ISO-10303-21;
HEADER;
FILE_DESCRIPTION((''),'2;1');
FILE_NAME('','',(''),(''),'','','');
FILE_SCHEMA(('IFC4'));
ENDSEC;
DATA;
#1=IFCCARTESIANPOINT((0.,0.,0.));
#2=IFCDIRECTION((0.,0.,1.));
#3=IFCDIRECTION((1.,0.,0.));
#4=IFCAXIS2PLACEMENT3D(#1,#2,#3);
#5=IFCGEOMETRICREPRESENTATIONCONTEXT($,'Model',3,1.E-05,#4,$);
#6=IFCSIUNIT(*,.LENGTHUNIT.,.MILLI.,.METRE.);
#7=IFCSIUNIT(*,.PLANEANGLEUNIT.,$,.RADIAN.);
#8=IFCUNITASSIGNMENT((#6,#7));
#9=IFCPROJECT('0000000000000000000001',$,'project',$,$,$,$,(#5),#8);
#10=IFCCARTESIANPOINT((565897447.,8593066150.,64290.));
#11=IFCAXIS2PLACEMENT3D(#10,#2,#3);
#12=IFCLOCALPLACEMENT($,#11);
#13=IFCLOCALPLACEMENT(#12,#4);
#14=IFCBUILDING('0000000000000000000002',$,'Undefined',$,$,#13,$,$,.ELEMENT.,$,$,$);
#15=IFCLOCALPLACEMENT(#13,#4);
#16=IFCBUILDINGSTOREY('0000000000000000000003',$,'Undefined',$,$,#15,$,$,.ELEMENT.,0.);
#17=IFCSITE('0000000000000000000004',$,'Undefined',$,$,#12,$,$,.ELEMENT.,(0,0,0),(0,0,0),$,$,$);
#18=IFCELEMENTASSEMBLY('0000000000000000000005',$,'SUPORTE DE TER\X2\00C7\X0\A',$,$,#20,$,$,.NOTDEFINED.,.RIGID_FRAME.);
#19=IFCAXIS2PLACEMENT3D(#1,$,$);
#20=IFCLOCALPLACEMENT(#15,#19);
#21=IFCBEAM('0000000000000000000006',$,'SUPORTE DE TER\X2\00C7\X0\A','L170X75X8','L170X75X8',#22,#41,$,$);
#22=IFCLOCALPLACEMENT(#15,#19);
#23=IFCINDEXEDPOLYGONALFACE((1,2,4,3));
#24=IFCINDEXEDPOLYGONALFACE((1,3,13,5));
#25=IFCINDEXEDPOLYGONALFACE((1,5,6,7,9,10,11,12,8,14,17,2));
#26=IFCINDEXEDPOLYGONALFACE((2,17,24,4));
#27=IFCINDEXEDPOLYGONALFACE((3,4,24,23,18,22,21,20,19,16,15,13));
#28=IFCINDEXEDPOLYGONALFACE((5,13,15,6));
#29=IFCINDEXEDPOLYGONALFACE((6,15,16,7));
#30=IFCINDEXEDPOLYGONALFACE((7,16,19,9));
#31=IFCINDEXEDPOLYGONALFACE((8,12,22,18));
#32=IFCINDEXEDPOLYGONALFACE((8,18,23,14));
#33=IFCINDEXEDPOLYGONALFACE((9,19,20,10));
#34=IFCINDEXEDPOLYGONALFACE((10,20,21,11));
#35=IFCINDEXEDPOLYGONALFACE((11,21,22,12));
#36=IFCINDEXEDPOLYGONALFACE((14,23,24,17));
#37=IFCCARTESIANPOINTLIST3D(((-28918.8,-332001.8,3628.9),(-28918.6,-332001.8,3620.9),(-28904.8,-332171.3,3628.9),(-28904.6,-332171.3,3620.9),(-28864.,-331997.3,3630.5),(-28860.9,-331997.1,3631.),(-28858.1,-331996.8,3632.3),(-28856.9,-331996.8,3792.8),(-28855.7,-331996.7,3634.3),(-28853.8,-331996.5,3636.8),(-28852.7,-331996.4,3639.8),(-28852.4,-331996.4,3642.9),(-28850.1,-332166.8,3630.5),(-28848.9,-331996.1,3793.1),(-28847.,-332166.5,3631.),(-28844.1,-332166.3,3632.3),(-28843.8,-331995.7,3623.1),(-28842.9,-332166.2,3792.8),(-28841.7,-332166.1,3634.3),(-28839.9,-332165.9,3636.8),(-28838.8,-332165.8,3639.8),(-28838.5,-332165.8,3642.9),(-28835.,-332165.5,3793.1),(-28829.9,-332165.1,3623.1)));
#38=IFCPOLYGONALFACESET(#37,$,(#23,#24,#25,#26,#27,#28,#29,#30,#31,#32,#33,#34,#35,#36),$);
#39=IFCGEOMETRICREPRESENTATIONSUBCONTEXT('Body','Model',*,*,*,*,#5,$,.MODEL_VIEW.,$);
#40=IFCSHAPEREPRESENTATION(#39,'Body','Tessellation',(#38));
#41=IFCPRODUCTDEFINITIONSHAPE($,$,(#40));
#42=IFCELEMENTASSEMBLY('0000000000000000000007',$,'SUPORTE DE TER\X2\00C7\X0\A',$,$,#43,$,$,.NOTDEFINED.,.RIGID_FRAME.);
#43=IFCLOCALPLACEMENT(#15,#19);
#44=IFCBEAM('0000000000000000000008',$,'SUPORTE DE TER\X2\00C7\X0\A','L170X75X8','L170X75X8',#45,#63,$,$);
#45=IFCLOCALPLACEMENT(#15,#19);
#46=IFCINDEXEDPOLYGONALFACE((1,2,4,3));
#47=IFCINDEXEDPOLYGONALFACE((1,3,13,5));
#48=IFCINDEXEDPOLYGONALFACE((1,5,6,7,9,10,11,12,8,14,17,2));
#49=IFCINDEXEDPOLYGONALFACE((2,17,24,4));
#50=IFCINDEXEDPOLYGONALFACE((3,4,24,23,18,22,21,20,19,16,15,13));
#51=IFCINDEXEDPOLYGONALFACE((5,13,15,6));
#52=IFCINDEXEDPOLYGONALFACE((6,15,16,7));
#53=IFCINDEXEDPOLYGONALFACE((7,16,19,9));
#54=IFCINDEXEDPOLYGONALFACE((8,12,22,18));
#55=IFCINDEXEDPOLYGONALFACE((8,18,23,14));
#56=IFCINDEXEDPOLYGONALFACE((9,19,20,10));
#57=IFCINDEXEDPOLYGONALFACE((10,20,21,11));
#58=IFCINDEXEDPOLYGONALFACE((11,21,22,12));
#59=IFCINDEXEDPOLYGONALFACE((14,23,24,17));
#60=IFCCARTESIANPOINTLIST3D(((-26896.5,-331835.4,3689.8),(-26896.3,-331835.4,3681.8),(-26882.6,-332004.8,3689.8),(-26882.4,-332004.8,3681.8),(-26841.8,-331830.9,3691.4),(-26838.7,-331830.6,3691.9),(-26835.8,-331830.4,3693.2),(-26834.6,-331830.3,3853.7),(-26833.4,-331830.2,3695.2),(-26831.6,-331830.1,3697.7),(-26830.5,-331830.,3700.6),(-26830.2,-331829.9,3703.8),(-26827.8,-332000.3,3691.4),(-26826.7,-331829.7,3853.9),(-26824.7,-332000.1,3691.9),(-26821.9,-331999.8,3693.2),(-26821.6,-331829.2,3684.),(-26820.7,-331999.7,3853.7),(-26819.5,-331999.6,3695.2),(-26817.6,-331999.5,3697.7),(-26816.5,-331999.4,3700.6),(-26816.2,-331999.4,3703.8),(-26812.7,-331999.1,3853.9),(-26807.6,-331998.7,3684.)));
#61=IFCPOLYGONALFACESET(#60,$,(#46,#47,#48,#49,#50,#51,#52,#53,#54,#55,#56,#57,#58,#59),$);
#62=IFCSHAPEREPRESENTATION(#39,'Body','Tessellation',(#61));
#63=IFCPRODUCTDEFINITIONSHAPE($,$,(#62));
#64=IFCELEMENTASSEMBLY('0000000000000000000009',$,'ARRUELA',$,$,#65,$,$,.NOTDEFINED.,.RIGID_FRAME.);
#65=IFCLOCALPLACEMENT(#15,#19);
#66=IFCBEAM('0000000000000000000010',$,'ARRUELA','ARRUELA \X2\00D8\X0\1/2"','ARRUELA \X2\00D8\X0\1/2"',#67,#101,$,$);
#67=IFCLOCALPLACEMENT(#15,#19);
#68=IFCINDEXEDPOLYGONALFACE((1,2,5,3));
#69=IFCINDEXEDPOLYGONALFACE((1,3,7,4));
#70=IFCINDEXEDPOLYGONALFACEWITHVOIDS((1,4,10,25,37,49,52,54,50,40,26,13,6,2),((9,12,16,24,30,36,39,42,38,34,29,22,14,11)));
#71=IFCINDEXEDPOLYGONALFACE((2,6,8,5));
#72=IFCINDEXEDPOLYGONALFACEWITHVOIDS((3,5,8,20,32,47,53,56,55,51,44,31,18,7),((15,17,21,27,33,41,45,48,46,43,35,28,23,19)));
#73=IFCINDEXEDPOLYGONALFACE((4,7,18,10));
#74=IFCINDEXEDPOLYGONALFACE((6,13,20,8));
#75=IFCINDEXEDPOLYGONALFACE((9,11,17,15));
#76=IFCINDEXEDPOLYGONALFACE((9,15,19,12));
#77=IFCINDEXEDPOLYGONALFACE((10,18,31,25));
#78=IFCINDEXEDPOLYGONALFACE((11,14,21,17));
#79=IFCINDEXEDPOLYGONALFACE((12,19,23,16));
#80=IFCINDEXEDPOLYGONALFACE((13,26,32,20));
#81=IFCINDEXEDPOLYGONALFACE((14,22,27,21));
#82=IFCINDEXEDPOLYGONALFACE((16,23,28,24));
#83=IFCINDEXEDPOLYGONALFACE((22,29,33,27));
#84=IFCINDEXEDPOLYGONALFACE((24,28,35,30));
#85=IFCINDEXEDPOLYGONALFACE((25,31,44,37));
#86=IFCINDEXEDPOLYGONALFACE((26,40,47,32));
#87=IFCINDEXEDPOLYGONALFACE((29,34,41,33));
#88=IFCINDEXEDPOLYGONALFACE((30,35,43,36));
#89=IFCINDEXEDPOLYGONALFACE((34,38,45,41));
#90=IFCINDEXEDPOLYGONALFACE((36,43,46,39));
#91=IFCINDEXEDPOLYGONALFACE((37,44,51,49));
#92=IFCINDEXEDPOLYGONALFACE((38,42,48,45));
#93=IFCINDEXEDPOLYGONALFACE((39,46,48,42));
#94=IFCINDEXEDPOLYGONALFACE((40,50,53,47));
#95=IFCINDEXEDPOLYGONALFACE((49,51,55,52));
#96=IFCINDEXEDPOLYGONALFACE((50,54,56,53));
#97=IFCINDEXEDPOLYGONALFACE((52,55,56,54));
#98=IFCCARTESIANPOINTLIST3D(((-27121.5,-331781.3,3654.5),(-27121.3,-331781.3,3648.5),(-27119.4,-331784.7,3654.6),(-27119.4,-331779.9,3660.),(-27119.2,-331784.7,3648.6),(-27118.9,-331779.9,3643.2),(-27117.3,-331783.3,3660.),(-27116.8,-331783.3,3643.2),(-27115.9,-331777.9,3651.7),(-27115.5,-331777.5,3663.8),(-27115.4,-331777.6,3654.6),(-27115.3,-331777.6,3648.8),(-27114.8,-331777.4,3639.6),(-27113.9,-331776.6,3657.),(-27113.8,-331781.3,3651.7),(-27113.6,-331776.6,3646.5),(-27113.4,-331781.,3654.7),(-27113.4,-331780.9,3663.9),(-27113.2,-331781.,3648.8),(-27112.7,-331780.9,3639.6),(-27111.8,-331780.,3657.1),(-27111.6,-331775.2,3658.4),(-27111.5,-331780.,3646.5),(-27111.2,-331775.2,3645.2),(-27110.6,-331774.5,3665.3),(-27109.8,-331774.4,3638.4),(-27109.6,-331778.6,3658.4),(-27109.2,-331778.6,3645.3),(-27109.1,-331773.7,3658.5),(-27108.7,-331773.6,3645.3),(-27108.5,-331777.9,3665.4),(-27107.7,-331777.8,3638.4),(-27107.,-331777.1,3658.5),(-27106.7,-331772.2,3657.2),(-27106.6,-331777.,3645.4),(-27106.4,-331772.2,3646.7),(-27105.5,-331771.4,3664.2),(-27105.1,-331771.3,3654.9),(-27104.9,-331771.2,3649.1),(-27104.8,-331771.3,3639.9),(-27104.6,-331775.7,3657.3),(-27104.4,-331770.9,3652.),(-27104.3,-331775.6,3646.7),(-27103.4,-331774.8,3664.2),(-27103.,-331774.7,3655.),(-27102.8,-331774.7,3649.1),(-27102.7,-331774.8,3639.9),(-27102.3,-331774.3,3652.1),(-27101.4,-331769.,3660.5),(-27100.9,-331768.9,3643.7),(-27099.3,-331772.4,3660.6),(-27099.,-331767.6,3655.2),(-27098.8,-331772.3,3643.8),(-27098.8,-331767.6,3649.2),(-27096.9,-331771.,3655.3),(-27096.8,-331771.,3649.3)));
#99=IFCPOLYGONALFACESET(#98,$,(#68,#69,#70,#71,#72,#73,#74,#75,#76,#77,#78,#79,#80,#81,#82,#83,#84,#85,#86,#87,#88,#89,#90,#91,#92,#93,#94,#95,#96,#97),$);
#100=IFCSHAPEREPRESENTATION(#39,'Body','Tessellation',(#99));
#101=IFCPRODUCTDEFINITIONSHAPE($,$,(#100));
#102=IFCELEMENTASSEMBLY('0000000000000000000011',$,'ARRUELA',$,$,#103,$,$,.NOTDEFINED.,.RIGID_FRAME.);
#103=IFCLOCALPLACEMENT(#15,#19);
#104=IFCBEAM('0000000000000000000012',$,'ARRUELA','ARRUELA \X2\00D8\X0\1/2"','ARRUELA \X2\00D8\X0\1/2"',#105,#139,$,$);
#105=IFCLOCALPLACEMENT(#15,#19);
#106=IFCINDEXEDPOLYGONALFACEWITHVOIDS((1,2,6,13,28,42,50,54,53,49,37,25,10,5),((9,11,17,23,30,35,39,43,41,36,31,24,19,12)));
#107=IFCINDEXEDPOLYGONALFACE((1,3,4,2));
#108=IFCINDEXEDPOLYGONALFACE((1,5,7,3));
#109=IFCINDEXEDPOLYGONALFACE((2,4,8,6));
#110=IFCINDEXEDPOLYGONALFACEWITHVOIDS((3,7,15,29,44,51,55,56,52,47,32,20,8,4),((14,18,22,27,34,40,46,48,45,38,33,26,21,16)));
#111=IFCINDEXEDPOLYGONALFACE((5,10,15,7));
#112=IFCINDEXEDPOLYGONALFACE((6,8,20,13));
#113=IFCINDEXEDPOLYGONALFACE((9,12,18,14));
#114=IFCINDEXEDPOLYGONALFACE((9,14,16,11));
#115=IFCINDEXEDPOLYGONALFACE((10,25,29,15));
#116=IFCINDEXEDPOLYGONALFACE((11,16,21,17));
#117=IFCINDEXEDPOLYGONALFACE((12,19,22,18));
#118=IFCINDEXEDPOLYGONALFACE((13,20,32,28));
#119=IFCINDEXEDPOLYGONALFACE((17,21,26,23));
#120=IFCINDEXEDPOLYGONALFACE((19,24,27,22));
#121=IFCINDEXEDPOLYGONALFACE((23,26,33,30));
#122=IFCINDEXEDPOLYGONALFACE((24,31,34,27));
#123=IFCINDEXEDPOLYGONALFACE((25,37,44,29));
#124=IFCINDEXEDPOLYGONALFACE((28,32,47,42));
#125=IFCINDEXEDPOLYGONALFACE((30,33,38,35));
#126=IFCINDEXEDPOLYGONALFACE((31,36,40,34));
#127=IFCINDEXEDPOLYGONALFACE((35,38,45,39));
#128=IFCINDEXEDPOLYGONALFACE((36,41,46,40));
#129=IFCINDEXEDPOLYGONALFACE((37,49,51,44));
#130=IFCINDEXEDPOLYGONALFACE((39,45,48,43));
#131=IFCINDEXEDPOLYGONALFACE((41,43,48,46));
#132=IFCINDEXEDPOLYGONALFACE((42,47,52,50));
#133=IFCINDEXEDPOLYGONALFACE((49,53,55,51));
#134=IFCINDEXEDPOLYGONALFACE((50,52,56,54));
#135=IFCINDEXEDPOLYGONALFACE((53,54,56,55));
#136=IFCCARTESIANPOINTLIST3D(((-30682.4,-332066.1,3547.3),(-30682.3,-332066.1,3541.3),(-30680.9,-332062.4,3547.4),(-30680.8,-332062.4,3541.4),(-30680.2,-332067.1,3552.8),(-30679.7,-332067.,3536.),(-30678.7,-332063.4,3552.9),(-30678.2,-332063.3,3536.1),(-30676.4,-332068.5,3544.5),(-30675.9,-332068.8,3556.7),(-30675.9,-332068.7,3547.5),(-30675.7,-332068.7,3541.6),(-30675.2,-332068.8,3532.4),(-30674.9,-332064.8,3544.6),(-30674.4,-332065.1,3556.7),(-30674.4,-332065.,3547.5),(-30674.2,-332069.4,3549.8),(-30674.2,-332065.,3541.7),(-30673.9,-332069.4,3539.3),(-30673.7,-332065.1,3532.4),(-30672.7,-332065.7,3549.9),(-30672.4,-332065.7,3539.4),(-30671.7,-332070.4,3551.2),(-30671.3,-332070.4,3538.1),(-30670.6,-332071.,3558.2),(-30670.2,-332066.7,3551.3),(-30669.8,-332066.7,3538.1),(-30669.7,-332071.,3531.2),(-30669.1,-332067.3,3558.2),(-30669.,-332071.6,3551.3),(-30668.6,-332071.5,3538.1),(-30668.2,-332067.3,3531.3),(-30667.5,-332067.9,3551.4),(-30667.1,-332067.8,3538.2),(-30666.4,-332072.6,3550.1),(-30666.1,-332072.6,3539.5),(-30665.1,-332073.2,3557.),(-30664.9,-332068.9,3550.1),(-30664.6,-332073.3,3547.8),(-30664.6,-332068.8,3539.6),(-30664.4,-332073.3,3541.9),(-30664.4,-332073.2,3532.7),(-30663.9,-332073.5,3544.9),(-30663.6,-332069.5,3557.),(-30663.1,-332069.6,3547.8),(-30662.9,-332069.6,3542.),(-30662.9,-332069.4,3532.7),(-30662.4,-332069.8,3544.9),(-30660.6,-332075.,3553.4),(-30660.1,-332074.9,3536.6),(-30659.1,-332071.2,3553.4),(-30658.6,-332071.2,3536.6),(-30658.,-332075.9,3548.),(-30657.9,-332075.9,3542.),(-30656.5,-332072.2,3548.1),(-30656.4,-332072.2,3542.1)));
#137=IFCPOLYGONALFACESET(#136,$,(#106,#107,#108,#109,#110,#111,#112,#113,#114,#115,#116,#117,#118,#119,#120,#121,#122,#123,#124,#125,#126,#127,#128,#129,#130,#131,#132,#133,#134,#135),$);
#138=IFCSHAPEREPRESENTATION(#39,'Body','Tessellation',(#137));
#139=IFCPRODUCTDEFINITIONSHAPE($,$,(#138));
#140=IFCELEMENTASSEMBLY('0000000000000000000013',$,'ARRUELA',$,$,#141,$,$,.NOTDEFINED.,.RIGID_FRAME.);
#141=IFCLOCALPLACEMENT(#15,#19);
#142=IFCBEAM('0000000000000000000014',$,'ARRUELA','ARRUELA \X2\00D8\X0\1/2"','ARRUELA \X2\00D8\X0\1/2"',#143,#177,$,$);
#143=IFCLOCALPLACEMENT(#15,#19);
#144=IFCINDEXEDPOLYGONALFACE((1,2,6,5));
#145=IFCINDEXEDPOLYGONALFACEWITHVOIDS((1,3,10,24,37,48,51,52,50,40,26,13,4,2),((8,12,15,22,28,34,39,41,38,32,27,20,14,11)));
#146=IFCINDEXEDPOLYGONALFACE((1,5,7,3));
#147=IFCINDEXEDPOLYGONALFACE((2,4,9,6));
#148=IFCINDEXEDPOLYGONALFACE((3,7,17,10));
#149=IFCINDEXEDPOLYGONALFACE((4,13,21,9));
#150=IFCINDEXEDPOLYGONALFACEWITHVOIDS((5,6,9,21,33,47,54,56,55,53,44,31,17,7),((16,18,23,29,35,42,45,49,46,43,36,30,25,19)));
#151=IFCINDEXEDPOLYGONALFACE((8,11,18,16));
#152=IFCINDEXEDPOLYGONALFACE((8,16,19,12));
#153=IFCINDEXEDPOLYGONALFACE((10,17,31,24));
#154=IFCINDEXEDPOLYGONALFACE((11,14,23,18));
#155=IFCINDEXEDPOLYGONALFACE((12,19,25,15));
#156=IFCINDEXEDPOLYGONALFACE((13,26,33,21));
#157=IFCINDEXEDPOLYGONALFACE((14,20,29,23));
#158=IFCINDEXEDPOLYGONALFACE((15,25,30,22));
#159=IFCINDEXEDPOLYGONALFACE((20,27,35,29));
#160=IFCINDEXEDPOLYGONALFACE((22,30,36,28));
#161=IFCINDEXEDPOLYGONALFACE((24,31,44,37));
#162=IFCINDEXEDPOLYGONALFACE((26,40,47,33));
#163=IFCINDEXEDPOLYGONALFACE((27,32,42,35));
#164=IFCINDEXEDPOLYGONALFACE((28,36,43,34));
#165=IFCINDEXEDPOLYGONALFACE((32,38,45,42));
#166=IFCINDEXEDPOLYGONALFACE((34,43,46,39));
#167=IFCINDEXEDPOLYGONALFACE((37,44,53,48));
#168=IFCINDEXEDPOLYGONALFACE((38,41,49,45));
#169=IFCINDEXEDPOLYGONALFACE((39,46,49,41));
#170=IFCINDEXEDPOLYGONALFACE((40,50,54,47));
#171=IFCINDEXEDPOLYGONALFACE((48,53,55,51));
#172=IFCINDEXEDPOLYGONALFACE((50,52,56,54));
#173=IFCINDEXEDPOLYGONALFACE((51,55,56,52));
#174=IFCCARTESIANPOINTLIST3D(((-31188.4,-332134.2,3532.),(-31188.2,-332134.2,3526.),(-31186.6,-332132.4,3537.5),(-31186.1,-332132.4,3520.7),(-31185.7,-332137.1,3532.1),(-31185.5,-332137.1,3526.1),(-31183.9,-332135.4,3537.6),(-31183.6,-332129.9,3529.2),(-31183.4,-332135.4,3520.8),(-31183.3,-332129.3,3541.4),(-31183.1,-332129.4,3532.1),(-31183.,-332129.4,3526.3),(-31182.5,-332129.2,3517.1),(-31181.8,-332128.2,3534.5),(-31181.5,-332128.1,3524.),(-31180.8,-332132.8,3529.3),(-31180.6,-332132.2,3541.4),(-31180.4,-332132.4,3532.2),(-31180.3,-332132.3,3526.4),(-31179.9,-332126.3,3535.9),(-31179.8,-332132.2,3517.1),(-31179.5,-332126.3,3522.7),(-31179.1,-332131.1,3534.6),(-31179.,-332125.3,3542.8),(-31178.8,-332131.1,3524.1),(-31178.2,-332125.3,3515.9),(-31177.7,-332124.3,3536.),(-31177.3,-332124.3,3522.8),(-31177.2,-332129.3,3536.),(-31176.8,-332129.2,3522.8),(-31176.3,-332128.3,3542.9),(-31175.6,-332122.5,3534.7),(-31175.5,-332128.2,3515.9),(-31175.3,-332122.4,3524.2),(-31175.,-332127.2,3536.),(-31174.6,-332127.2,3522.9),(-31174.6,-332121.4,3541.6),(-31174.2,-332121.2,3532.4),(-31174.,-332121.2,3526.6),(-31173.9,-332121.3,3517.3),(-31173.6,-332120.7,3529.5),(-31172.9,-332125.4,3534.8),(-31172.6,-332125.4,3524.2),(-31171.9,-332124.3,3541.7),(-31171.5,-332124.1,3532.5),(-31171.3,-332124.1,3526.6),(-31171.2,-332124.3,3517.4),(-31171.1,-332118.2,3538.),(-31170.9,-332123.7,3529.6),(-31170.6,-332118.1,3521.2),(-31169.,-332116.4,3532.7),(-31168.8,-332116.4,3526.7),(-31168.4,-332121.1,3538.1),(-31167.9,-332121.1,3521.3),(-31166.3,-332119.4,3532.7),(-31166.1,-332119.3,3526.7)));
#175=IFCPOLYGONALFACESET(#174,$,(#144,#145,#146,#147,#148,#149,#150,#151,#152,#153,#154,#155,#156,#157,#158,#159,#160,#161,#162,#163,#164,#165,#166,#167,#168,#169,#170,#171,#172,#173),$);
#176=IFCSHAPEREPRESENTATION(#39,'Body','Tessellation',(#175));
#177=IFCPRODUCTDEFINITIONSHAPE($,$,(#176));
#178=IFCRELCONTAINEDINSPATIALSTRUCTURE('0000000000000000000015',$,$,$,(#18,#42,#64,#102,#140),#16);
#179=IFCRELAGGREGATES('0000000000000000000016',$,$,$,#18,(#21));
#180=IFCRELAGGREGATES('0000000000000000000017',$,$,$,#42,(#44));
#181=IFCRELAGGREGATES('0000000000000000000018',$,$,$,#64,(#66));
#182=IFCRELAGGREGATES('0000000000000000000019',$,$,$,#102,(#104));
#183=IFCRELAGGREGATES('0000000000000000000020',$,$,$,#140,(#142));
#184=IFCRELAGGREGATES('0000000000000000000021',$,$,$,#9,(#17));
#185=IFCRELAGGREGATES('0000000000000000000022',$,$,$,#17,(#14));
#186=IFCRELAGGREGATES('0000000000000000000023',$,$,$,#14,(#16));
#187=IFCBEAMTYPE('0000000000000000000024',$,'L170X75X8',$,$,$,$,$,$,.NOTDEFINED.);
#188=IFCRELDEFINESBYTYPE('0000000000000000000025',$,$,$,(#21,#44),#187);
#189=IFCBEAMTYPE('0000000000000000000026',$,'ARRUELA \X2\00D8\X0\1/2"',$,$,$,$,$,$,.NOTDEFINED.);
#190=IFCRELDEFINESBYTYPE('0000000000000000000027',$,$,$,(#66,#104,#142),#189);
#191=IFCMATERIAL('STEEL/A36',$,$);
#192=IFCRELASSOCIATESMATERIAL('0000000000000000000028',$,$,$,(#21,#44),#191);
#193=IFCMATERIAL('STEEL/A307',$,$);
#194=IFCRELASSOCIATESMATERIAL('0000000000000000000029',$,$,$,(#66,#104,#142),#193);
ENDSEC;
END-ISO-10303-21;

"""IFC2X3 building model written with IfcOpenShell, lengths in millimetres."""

from ifc_helpers import new_model, si_unit, frame, origin_with_axes, origin_2d_with_axis, place, context, subcontext, project, spatial, polyline, l_section, outline, extrude, material, type_object, element, aggregate, save


model = new_model("IFC2X3")

# Units and contexts
model_context = context("Model", 3, precision=1e-05, world=origin_with_axes())
body_context = subcontext(model_context, "Body", "Model", "MODEL_VIEW")
ifc_project = project(units=[si_unit("LENGTHUNIT", "METRE", prefix="MILLI"), si_unit("PLANEANGLEUNIT", "RADIAN")], contexts=[model_context])

# Site, building, storey
site_placement = place(None, frame((565897447.0, 8593066150.0, 64290.0), z_axis=(0.0, 0.0, 1.0), x_axis=(1.0, 0.0, 0.0)))
site = spatial("IfcSite", under=ifc_project, at=site_placement, Name="Undefined", CompositionType="ELEMENT", RefLatitude=(0, 0, 0), RefLongitude=(0, 0, 0))
building_placement = place(site_placement, origin_with_axes())
building = spatial("IfcBuilding", under=site, at=building_placement, Name="Undefined", CompositionType="ELEMENT")
storey_placement = place(building_placement, origin_with_axes())
storey = spatial("IfcBuildingStorey", under=building, at=storey_placement, Name="Undefined", CompositionType="ELEMENT", Elevation=0.0)

# Element assemblies, beams
ifc_material_1 = material(Name="STEEL/A36")
beam_type_1 = type_object("IfcBeamType", Name="L170X75X8", PredefinedType="NOTDEFINED")
assembly_1_placement = place(storey_placement, origin_with_axes())
assembly_1 = element("IfcElementAssembly", 1, at=assembly_1_placement, inside=storey, Name="SUPORTE DE TERÇA", AssemblyPlace="NOTDEFINED", PredefinedType="RIGID_FRAME")
beam_1_placement = place(assembly_1_placement, frame((-28883.7, -331999.0, 3707.0), z_axis=(-0.029885, -0.00246, 0.99955), x_axis=(0.082025, -0.99663, 0.0)))
beam_1 = element("IfcBeam", 2, at=beam_1_placement, type_object=beam_type_1, material=ifc_material_1, Name="SUPORTE DE TERÇA", Description="L170X75X8", ObjectType="L170X75X8", context=body_context, shape_type="SweptSolid", body=[
    extrude(l_section(Depth=170.0, Width=75.0, Thickness=8.0, FilletRadius=12.0, at=origin_2d_with_axis()), frame((170.0, 0.0, 0.0), z_axis=(-1.0, 0.0, 0.0), x_axis=(0.0, -1.0, 0.0)), (0.0, 0.0, 1.0), 170.0),
])
aggregate(assembly_1, [beam_1])
assembly_2_placement = place(storey_placement, origin_with_axes())
assembly_2 = element("IfcElementAssembly", 3, at=assembly_2_placement, inside=storey, Name="SUPORTE DE TERÇA", AssemblyPlace="NOTDEFINED", PredefinedType="RIGID_FRAME")
beam_2_placement = place(assembly_2_placement, frame((-26861.5, -331832.5, 3767.8), z_axis=(-0.029885, -0.00246, 0.99955), x_axis=(0.082025, -0.99663, 0.0)))
beam_2 = element("IfcBeam", 4, at=beam_2_placement, type_object=beam_type_1, material=ifc_material_1, Name="SUPORTE DE TERÇA", Description="L170X75X8", ObjectType="L170X75X8", context=body_context, shape_type="SweptSolid", body=[
    extrude(l_section(Depth=170.0, Width=75.0, Thickness=8.0, FilletRadius=12.0, at=origin_2d_with_axis()), frame((170.0, 0.0, 0.0), z_axis=(-1.0, 0.0, 0.0), x_axis=(0.0, -1.0, 0.0)), (0.0, 0.0, 1.0), 170.0),
])
aggregate(assembly_2, [beam_2])
assembly_3_placement = place(storey_placement, origin_with_axes())
assembly_3 = element("IfcElementAssembly", 5, at=assembly_3_placement, inside=storey, Name="ARRUELA", AssemblyPlace="NOTDEFINED", PredefinedType="RIGID_FRAME")
ifc_material_2 = material(Name="STEEL/A307")
beam_type_2 = type_object("IfcBeamType", Name="ARRUELA Ø1/2\"", PredefinedType="NOTDEFINED")
beam_3_placement = place(assembly_3_placement, frame((-27108.1, -331777.8, 3651.9), z_axis=(-0.853486, -0.520426, -0.026799), x_axis=(-0.520257, 0.853904, -0.013454)))
beam_3 = element("IfcBeam", 6, at=beam_3_placement, type_object=beam_type_2, material=ifc_material_2, Name="ARRUELA", Description="ARRUELA Ø1/2\"", ObjectType="ARRUELA Ø1/2\"", context=body_context, shape_type="SweptSolid", body=[
    extrude(outline(polyline([(-8.4, 10.5), (-3.0, 13.2), (3.0, 13.2), (8.4, 10.5), (12.2, 5.9), (13.5, 0.0), (12.2, -5.9), (8.4, -10.5), (3.0, -13.2), (-3.0, -13.2), (-8.4, -10.5), (-12.2, -5.9), (-13.5, 0.0), (-12.2, 5.9), (-8.4, 10.5)]), holes=[polyline([(5.3, 4.2), (2.9, 6.1), (0.0, 6.7), (-2.9, 6.1), (-5.3, 4.2), (-6.6, 1.5), (-6.6, -1.5), (-5.3, -4.2), (-2.9, -6.1), (0.0, -6.8), (2.9, -6.1), (5.3, -4.2), (6.6, -1.5), (6.6, 1.5), (5.3, 4.2)])]), frame((4.0, 0.0, 0.0), z_axis=(-1.0, 0.0, 0.0), x_axis=(0.0, -1.0, 0.0)), (0.0, 0.0, 1.0), 4.0),
])
aggregate(assembly_3, [beam_3])
assembly_4_placement = place(storey_placement, origin_with_axes())
assembly_4 = element("IfcElementAssembly", 7, at=assembly_4_placement, inside=storey, Name="ARRUELA", AssemblyPlace="NOTDEFINED", PredefinedType="RIGID_FRAME")
beam_4_placement = place(assembly_4_placement, frame((-30670.1, -332071.0, 3544.7), z_axis=(-0.92709, 0.373879, -0.026799), x_axis=(0.373645, 0.927474, 0.013454)))
beam_4 = element("IfcBeam", 8, at=beam_4_placement, type_object=beam_type_2, material=ifc_material_2, Name="ARRUELA", Description="ARRUELA Ø1/2\"", ObjectType="ARRUELA Ø1/2\"", context=body_context, shape_type="SweptSolid", body=[
    extrude(outline(polyline([(-8.4, 10.5), (-3.0, 13.2), (3.0, 13.2), (8.4, 10.5), (12.2, 5.9), (13.5, 0.0), (12.2, -5.9), (8.4, -10.5), (3.0, -13.2), (-3.0, -13.2), (-8.4, -10.5), (-12.2, -5.9), (-13.5, 0.0), (-12.2, 5.9), (-8.4, 10.5)]), holes=[polyline([(5.3, 4.2), (2.9, 6.1), (0.0, 6.7), (-2.9, 6.1), (-5.3, 4.2), (-6.6, 1.5), (-6.6, -1.5), (-5.3, -4.2), (-2.9, -6.1), (0.0, -6.8), (2.9, -6.1), (5.3, -4.2), (6.6, -1.5), (6.6, 1.5), (5.3, 4.2)])]), frame((4.0, 0.0, 0.0), z_axis=(-1.0, 0.0, 0.0), x_axis=(0.0, -1.0, 0.0)), (0.0, 0.0, 1.0), 4.0),
])
aggregate(assembly_4, [beam_4])
assembly_5_placement = place(storey_placement, origin_with_axes())
assembly_5 = element("IfcElementAssembly", 9, at=assembly_5_placement, inside=storey, Name="ARRUELA", AssemblyPlace="NOTDEFINED", PredefinedType="RIGID_FRAME")
beam_5_placement = place(assembly_5_placement, frame((-31175.9, -332128.2, 3529.4), z_axis=(-0.736334, -0.676203, -0.02368), x_axis=(-0.675958, 0.736711, -0.018398)))
beam_5 = element("IfcBeam", 10, at=beam_5_placement, type_object=beam_type_2, material=ifc_material_2, Name="ARRUELA", Description="ARRUELA Ø1/2\"", ObjectType="ARRUELA Ø1/2\"", context=body_context, shape_type="SweptSolid", body=[
    extrude(outline(polyline([(-8.4, 10.5), (-3.0, 13.2), (3.0, 13.2), (8.4, 10.5), (12.2, 5.9), (13.5, 0.0), (12.2, -5.9), (8.4, -10.5), (3.0, -13.2), (-3.0, -13.2), (-8.4, -10.5), (-12.2, -5.9), (-13.5, 0.0), (-12.2, 5.9), (-8.4, 10.5)]), holes=[polyline([(5.3, 4.2), (2.9, 6.1), (0.0, 6.7), (-2.9, 6.1), (-5.3, 4.2), (-6.6, 1.5), (-6.6, -1.5), (-5.3, -4.2), (-2.9, -6.1), (0.0, -6.8), (2.9, -6.1), (5.3, -4.2), (6.6, -1.5), (6.6, 1.5), (5.3, 4.2)])]), frame((4.0, 0.0, 0.0), z_axis=(-1.0, 0.0, 0.0), x_axis=(0.0, -1.0, 0.0)), (0.0, 0.0, 1.0), 4.0),
])
aggregate(assembly_5, [beam_5])

save(model, "model.ifc")
